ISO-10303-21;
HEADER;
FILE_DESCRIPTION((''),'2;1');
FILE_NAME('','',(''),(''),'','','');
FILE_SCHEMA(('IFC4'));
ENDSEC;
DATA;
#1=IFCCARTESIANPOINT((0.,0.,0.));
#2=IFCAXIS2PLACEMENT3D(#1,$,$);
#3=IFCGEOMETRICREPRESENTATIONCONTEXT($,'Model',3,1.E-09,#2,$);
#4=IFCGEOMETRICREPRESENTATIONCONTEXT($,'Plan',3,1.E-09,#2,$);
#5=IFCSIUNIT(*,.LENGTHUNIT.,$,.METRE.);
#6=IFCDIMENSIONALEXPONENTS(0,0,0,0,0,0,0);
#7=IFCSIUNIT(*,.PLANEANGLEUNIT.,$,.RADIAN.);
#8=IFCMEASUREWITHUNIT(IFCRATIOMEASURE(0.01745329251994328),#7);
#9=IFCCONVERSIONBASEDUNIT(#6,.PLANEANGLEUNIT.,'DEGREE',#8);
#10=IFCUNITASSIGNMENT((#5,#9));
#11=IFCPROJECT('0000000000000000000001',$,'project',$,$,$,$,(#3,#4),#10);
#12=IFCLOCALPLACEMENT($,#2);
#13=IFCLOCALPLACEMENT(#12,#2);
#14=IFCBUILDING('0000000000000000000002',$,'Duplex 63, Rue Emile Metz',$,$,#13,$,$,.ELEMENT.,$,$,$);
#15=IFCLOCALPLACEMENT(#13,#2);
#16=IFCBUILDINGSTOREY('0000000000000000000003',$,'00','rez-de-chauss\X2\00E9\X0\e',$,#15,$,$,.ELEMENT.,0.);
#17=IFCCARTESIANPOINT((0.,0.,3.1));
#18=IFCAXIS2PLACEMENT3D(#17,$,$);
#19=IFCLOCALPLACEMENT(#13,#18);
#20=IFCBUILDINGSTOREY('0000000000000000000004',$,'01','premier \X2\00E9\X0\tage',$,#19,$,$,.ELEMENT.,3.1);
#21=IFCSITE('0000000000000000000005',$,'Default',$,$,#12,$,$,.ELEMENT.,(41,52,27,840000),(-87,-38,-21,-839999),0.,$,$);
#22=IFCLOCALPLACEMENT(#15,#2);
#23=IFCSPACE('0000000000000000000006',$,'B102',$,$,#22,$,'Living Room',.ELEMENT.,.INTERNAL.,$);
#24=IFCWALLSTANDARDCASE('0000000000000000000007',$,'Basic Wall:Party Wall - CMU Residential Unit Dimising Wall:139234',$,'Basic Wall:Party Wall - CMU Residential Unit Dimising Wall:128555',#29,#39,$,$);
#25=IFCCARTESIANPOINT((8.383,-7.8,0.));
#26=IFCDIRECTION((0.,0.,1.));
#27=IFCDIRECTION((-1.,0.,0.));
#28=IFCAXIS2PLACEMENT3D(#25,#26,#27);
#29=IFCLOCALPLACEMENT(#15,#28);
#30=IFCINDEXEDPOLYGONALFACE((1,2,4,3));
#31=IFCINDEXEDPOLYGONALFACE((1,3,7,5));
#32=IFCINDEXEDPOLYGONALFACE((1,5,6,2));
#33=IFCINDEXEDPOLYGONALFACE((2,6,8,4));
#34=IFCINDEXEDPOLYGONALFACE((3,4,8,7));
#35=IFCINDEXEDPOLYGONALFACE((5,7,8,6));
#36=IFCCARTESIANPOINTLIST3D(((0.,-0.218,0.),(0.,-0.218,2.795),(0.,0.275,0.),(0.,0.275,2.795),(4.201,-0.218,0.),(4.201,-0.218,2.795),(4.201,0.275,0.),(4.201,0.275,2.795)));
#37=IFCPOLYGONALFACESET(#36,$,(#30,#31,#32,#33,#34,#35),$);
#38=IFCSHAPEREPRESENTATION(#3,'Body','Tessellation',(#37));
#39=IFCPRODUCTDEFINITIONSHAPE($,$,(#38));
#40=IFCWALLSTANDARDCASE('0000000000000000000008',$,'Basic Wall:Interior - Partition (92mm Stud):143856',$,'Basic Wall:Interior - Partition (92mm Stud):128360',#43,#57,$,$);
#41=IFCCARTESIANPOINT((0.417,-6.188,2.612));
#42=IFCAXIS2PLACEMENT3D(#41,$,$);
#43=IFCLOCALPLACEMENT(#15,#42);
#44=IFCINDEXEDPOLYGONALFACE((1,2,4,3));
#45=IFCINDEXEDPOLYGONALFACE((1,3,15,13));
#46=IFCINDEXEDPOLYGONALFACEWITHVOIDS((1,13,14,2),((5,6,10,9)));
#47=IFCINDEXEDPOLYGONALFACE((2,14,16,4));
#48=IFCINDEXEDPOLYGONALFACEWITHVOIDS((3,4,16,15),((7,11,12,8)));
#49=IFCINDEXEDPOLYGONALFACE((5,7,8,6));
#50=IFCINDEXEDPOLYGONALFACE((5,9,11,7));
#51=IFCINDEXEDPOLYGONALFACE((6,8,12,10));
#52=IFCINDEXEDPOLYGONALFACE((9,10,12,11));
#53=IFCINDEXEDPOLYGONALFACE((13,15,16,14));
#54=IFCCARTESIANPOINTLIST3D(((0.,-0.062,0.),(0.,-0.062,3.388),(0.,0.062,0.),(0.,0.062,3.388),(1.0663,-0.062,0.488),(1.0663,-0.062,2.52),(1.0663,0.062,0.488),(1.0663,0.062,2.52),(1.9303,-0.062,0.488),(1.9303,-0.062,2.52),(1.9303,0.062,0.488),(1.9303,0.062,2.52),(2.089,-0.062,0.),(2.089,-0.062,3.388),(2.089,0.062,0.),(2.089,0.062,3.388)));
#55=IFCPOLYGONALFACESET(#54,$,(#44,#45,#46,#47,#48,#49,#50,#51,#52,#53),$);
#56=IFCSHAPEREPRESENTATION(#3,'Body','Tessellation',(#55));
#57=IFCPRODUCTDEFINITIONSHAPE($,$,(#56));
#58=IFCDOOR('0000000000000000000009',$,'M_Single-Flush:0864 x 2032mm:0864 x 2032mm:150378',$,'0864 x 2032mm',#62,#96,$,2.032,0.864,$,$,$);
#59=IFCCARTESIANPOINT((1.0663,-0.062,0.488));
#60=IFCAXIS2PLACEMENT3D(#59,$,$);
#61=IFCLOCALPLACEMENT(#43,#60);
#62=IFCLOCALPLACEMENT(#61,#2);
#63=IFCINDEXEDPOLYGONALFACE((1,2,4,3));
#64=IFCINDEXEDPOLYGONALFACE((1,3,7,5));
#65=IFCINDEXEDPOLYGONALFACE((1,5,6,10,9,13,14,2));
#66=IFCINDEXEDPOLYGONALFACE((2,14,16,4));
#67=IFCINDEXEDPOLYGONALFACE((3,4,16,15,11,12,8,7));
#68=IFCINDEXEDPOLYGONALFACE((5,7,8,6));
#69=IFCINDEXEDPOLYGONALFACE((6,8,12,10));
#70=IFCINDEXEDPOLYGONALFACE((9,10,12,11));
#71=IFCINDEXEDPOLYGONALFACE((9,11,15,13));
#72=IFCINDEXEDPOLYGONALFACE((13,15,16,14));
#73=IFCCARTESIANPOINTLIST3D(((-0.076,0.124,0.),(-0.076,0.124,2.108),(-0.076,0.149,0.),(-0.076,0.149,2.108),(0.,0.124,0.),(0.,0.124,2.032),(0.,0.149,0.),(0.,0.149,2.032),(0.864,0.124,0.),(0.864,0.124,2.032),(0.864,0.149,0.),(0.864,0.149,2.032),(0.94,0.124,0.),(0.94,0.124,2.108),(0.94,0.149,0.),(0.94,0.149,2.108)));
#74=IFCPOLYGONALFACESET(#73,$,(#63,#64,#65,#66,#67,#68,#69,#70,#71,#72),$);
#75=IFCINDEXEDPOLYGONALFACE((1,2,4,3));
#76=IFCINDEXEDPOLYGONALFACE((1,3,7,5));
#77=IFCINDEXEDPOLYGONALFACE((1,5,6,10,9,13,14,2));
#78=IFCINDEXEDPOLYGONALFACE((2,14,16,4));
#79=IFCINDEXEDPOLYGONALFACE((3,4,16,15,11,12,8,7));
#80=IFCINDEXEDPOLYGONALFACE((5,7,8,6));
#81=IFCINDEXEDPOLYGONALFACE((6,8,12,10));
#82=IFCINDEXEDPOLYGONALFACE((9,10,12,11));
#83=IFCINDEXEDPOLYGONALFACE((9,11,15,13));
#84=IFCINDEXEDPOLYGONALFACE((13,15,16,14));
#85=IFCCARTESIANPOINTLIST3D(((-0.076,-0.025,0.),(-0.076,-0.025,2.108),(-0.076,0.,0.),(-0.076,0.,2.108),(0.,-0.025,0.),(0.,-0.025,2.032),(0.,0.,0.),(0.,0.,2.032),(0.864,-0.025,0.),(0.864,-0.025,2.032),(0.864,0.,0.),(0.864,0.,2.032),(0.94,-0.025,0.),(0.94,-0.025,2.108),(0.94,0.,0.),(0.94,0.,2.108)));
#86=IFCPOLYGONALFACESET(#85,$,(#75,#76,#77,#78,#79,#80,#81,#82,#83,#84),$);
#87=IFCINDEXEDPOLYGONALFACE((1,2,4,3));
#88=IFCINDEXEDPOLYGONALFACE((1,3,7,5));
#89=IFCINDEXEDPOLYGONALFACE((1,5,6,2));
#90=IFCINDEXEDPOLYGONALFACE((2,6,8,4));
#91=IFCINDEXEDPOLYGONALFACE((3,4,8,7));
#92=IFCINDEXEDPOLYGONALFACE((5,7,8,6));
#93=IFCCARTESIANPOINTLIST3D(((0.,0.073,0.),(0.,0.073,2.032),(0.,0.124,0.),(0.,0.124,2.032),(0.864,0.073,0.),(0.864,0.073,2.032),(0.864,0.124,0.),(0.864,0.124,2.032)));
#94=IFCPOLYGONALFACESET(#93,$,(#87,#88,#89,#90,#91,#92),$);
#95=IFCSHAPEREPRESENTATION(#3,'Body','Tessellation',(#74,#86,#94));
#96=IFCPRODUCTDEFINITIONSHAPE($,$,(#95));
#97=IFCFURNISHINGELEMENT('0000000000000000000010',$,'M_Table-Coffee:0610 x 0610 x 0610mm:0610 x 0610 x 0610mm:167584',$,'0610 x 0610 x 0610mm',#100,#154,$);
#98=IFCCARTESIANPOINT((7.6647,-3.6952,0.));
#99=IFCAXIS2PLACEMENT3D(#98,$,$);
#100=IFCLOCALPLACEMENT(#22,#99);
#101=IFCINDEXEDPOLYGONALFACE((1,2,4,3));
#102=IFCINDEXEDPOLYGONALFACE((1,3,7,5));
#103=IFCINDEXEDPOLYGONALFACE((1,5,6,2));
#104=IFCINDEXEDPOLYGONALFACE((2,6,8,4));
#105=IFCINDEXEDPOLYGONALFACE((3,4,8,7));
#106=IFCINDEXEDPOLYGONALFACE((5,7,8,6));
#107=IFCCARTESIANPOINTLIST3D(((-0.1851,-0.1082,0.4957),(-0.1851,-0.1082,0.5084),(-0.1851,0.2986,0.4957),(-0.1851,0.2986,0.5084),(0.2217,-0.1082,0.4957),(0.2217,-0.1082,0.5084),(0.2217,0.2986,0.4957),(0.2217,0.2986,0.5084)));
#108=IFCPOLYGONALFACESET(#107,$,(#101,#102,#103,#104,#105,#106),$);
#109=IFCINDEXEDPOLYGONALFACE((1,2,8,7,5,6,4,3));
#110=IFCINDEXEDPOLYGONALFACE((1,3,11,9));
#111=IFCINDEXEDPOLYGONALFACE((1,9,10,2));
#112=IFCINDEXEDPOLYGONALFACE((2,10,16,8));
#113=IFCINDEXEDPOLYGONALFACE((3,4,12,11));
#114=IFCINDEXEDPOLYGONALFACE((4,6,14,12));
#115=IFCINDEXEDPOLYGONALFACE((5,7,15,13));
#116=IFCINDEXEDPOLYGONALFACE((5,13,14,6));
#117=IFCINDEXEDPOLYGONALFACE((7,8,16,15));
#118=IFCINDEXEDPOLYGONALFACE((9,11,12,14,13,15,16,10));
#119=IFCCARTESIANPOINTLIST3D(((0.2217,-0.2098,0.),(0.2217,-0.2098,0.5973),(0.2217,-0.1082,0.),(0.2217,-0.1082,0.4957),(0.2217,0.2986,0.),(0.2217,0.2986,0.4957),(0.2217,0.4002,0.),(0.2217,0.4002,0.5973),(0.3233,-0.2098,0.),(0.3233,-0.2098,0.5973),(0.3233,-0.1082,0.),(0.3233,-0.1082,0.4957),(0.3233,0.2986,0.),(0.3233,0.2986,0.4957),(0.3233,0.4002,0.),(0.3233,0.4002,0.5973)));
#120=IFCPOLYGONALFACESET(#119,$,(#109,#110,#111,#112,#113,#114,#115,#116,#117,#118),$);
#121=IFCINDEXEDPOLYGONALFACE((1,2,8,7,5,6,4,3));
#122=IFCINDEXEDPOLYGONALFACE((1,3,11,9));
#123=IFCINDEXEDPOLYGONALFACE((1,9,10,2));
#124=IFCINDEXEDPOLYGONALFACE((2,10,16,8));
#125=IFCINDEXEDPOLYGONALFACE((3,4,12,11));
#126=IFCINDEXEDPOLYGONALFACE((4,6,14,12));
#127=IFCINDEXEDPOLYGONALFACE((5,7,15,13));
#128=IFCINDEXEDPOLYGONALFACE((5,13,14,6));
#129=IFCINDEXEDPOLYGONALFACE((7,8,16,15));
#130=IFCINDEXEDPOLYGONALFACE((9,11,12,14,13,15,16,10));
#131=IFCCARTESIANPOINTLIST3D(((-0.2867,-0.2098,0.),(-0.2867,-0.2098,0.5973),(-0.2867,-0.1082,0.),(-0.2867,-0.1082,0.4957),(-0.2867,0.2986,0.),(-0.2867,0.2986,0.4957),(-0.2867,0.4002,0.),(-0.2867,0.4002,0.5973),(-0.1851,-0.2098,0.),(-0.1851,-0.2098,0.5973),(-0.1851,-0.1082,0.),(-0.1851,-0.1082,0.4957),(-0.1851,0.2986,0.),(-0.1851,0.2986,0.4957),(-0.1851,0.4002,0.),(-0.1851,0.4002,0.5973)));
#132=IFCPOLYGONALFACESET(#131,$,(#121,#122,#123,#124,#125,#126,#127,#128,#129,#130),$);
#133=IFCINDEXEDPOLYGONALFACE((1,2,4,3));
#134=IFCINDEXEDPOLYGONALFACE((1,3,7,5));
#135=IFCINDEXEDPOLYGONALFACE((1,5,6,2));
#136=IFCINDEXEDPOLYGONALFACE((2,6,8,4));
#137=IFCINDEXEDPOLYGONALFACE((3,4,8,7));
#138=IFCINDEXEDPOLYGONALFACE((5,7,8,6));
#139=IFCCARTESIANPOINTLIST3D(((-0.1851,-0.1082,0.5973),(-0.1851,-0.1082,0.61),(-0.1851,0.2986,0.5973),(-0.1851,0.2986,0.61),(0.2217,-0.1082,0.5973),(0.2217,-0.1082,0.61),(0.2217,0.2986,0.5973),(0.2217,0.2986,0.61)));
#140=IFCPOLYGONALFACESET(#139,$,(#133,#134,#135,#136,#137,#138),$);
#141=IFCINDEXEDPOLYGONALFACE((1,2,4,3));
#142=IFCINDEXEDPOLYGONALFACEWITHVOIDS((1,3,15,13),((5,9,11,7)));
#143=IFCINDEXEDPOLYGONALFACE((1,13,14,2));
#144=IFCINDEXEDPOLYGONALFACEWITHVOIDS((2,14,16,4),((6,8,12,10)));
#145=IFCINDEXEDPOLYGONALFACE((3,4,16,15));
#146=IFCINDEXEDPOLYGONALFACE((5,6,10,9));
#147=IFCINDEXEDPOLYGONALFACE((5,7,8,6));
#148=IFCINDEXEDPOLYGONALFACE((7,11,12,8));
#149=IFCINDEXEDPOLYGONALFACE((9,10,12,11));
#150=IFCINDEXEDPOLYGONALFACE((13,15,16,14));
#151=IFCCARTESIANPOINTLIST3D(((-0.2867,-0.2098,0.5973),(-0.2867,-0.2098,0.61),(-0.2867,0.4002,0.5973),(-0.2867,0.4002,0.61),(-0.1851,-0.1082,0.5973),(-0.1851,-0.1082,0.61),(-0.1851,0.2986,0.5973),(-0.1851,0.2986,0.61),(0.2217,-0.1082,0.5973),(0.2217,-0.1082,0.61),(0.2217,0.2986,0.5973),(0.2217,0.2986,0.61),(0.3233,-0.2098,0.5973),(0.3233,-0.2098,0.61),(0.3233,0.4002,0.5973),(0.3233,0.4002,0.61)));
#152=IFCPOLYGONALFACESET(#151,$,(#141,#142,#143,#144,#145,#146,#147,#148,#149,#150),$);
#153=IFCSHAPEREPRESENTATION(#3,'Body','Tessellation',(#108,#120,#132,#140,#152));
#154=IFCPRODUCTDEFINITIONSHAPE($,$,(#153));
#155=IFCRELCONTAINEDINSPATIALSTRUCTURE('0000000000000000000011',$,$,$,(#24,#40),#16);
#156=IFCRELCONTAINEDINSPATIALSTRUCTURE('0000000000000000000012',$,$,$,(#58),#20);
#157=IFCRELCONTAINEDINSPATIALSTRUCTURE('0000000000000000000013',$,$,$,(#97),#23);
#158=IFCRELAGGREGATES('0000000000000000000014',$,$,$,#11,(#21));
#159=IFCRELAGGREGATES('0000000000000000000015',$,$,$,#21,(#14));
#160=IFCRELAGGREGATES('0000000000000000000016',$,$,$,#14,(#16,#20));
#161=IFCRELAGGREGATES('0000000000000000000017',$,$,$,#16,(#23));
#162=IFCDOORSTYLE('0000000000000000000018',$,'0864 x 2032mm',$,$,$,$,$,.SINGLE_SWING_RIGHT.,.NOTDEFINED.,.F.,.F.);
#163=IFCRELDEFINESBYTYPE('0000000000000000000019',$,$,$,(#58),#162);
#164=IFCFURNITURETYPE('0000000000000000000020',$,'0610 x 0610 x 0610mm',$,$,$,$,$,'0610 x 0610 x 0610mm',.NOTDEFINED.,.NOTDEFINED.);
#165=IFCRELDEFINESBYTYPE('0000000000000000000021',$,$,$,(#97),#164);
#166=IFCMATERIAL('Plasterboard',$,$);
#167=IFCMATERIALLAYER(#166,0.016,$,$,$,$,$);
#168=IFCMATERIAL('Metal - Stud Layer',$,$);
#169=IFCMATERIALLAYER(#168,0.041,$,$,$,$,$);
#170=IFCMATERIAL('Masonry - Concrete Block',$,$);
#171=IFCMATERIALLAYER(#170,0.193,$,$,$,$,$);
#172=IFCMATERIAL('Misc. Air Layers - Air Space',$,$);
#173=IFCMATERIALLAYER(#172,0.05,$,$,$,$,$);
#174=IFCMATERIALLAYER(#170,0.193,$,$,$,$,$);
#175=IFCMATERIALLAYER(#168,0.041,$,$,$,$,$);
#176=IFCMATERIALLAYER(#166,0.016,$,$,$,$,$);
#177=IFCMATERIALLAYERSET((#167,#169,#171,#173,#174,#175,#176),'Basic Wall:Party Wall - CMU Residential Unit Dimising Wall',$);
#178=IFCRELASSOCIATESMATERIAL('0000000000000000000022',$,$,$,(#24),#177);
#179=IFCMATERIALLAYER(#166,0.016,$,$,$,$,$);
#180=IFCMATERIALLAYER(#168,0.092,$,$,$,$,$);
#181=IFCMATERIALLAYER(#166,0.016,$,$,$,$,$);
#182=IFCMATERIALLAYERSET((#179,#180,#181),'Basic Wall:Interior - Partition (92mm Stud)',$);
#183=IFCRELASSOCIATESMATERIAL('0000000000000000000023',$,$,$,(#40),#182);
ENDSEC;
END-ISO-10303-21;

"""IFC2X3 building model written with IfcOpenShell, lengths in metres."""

from ifc_helpers import new_model, entity, si_unit, converted_unit, frame, frame_2d, origin, origin_2d_with_axis, place, context, project, spatial, polyline, rectangle, outline, extrude, clip, bounded_halfspace, source, transform, mapped, material, layer, layer_set, layer_usage, type_object, type_shapes, element, fill, save


model = new_model("IFC2X3")

# Units and contexts
model_context = context("Model", 3, precision=1e-09, world=origin())
plan_context = context("Plan", 3, precision=1e-09, world=origin())
ifc_project = project(units=[si_unit("LENGTHUNIT", "METRE"), converted_unit("PLANEANGLEUNIT", "DEGREE", entity("IfcRatioMeasure", 0.01745329251994328), si_unit("PLANEANGLEUNIT", "RADIAN"), dimensions=[0, 0, 0, 0, 0, 0, 0])], contexts=[model_context, plan_context])

# Site, building, storey
site_placement = place(None, origin())
site = spatial("IfcSite", under=ifc_project, at=site_placement, Name="Default", CompositionType="ELEMENT", RefLatitude=(41, 52, 27, 840000), RefLongitude=(-87, -38, -21, -839999), RefElevation=0.0)
building_placement = place(site_placement, origin())
building = spatial("IfcBuilding", under=site, at=building_placement, Name="Duplex 63, Rue Emile Metz", CompositionType="ELEMENT")
storey_1_placement = place(building_placement, origin())
storey_1 = spatial("IfcBuildingStorey", under=building, at=storey_1_placement, Name="00", Description="rez-de-chaussée", CompositionType="ELEMENT", Elevation=0.0)

# Shared definitions
ifc_material_1 = material(Name="Misc. Air Layers - Air Space")
ifc_material_2 = material(Name="Masonry - Concrete Block")
ifc_material_3 = material(Name="Metal - Stud Layer")
ifc_material_4 = material(Name="Plasterboard")

# Wall
ifc_layer_1 = layer(ifc_material_4, 0.016)
ifc_layer_2 = layer(ifc_material_3, 0.041)
ifc_layer_3 = layer(ifc_material_2, 0.193)
ifc_layer_4 = layer(ifc_material_1, 0.05)
ifc_layer_5 = layer(ifc_material_2, 0.193)
ifc_layer_6 = layer(ifc_material_3, 0.041)
ifc_layer_7 = layer(ifc_material_4, 0.016)
ifc_layer_set_1 = layer_set([ifc_layer_1, ifc_layer_2, ifc_layer_3, ifc_layer_4, ifc_layer_5, ifc_layer_6, ifc_layer_7], Name="Basic Wall:Party Wall - CMU Residential Unit Dimising Wall")
ifc_layer_usage_1 = layer_usage(ifc_layer_set_1, "AXIS2", "NEGATIVE", 0.275)
wall_1_placement = place(storey_1_placement, frame((8.383, -7.8, 0.0), z_axis=(0.0, 0.0, 1.0), x_axis=(-1.0, 0.0, 0.0)))
element("IfcWallStandardCase", 1, at=wall_1_placement, inside=storey_1, material=ifc_layer_usage_1, Name="Basic Wall:Party Wall - CMU Residential Unit Dimising Wall:139234", ObjectType="Basic Wall:Party Wall - CMU Residential Unit Dimising Wall:128555", context=model_context, shape_type="Clipping", body=[
    clip(clip(extrude(rectangle(XDim=4.201, YDim=0.55, at=frame_2d((2.1005, 0.0), x_axis=(-1.0, 0.0))), origin(), (0.0, 0.0, 1.0), 2.795), bounded_halfspace(frame((0.0, -0.218, 2.795), z_axis=(0.0, 1.0, 0.0), x_axis=(-1.0, 0.0, 0.0)), True, frame((0.0, -0.218, 2.795), z_axis=(0.0, 1.0, 0.0), x_axis=(-1.0, 0.0, 0.0)), polyline([(0.0, 0.0), (-3.708, 0.0), (-4.201, 0.0), (-4.201, -2.795), (0.0, -2.795), (0.0, 0.0)]))), bounded_halfspace(frame((4.201, 0.275, 0.0), z_axis=(-1.0, 0.0, 0.0), x_axis=(0.0, -1.0, 0.0)), True, frame((4.201, 0.275, 0.0), z_axis=(-1.0, 0.0, 0.0), x_axis=(0.0, -1.0, 0.0)), polyline([(0.0, 0.0), (0.493, 0.0), (0.493, 2.795), (0.0, 2.795), (0.0, 0.0)]))),
])

# Wall, opening
ifc_layer_8 = layer(ifc_material_4, 0.016)
ifc_layer_9 = layer(ifc_material_3, 0.092)
ifc_layer_10 = layer(ifc_material_4, 0.016)
ifc_layer_set_2 = layer_set([ifc_layer_8, ifc_layer_9, ifc_layer_10], Name="Basic Wall:Interior - Partition (92mm Stud)")
ifc_layer_usage_2 = layer_usage(ifc_layer_set_2, "AXIS2", "NEGATIVE", 0.062)
wall_2_placement = place(storey_1_placement, frame((0.417, -6.188, 2.612)))
wall_2 = element("IfcWallStandardCase", 2, at=wall_2_placement, inside=storey_1, material=ifc_layer_usage_2, Name="Basic Wall:Interior - Partition (92mm Stud):143856", ObjectType="Basic Wall:Interior - Partition (92mm Stud):128360", context=model_context, shape_type="SweptSolid", body=[
    extrude(rectangle(XDim=2.089, YDim=0.124, at=frame_2d((1.0445, 0.0), x_axis=(-1.0, 0.0))), origin(), (0.0, 0.0, 1.0), 3.388),
])
opening_1_placement = place(wall_2_placement, frame((1.0663, -0.062, 0.488)))
opening_1 = element("IfcOpeningElement", 3, at=opening_1_placement, cuts=wall_2, ObjectType="Opening", context=model_context, shape_type="SweptSolid", body=[
    extrude(rectangle(XDim=0.864, YDim=2.032, at=frame_2d((1.016, 0.432), x_axis=(0.0, 1.0))), frame((0.0, 0.0, 0.0), z_axis=(0.0, 1.0, 0.0), x_axis=(0.0, 0.0, 1.0)), (0.0, 0.0, 1.0), 0.124),
])

# Shared definitions
storey_2_placement = place(building_placement, frame((0.0, 0.0, 3.1)))
storey_2 = spatial("IfcBuildingStorey", under=building, at=storey_2_placement, Name="01", Description="premier étage", CompositionType="ELEMENT", Elevation=3.1)

# Door
door_style_1 = type_object("IfcDoorStyle", Name="0864 x 2032mm", ConstructionType="NOTDEFINED", OperationType="SINGLE_SWING_RIGHT", ParameterTakesPrecedence=False, Sizeable=False)
shared_shape_1 = source(origin(), model_context, "Body", "SweptSolid", [
    extrude(outline(polyline([(-0.508, -1.073), (0.508, -1.073), (0.508, 1.035), (0.432, 1.035), (0.432, -0.997), (-0.432, -0.997), (-0.432, 1.035), (-0.508, 1.035), (-0.508, -1.073)])), frame((0.432, 0.124, 1.035), z_axis=(0.0, 1.0, 0.0), x_axis=(1.0, 0.0, 0.0)), (0.0, 0.0, 1.0), 0.025),
    extrude(outline(polyline([(-1.073, -0.508), (1.035, -0.508), (1.035, -0.432), (-0.997, -0.432), (-0.997, 0.432), (1.035, 0.432), (1.035, 0.508), (-1.073, 0.508), (-1.073, -0.508)])), frame((0.432, -0.025, 1.035), z_axis=(0.0, 1.0, 0.0), x_axis=(0.0, 0.0, -1.0)), (0.0, 0.0, 1.0), 0.025),
    extrude(rectangle(XDim=0.051, YDim=0.864, at=origin_2d_with_axis()), frame((0.432, 0.0985, 0.0), z_axis=(0.0, 0.0, 1.0), x_axis=(0.0, 1.0, 0.0)), (0.0, 0.0, 1.0), 2.032),
])
type_shapes(door_style_1, [shared_shape_1])
door_1_placement = place(opening_1_placement, origin())
door_1 = element("IfcDoor", 4, at=door_1_placement, inside=storey_2, type_object=door_style_1, Name="M_Single-Flush:0864 x 2032mm:0864 x 2032mm:150378", ObjectType="0864 x 2032mm", OverallHeight=2.032, OverallWidth=0.864, context=model_context, shape_type="MappedRepresentation", body=[
    mapped(shared_shape_1, transform((0.0, 0.0, 0.0), scale=1.0)),
])
fill(opening_1, door_1)

# Shared definitions
space_1_placement = place(storey_1_placement, origin())
space_1 = spatial("IfcSpace", under=storey_1, at=space_1_placement, Name="B102", LongName="Living Room", CompositionType="ELEMENT", InteriorOrExteriorSpace="INTERNAL")

# Furnishing element
furniture_type_1 = type_object("IfcFurnitureType", Name="0610 x 0610 x 0610mm", ElementType="0610 x 0610 x 0610mm", AssemblyPlace="NOTDEFINED")
shared_shape_2 = source(origin(), model_context, "Body", "SweptSolid", [
    extrude(rectangle(XDim=0.4068, YDim=0.4068, at=origin_2d_with_axis()), frame((0.0183, 0.0952, 0.4957), z_axis=(0.0, 0.0, 1.0), x_axis=(-1.0, 0.0, 0.0)), (0.0, 0.0, 1.0), 0.0127),
    extrude(outline(polyline([(-0.2732, -0.305), (0.324, -0.305), (0.324, 0.305), (-0.2732, 0.305), (-0.2732, 0.2034), (0.2225, 0.2034), (0.2225, -0.2034), (-0.2732, -0.2034), (-0.2732, -0.305)])), frame((0.2217, 0.0952, 0.2732), z_axis=(1.0, 0.0, 0.0), x_axis=(0.0, 0.0, 1.0)), (0.0, 0.0, 1.0), 0.1016),
    extrude(outline(polyline([(-0.305, -0.3241), (0.305, -0.3241), (0.305, 0.2733), (0.2034, 0.2733), (0.2034, -0.2224), (-0.2034, -0.2224), (-0.2034, 0.2733), (-0.305, 0.2733), (-0.305, -0.3241)])), frame((-0.2867, 0.0952, 0.2733), z_axis=(1.0, 0.0, 0.0), x_axis=(0.0, -1.0, 0.0)), (0.0, 0.0, 1.0), 0.1016),
    extrude(rectangle(XDim=0.4068, YDim=0.4068, at=origin_2d_with_axis()), frame((0.0183, 0.0952, 0.5973), z_axis=(0.0, 0.0, 1.0), x_axis=(-1.0, 0.0, 0.0)), (0.0, 0.0, 1.0), 0.0127),
    extrude(outline(polyline([(-0.305, -0.305), (0.305, -0.305), (0.305, 0.305), (-0.305, 0.305), (-0.305, -0.305)]), holes=[polyline([(-0.2034, -0.2034), (-0.2034, 0.2034), (0.2034, 0.2034), (0.2034, -0.2034), (-0.2034, -0.2034)])]), frame((0.0183, 0.0952, 0.5973), z_axis=(0.0, 0.0, 1.0), x_axis=(-1.0, 0.0, 0.0)), (0.0, 0.0, 1.0), 0.0127),
])
type_shapes(furniture_type_1, [shared_shape_2])
for number, where, name in (
    (5, (7.6647, -3.6952, 0.0), "M_Table-Coffee:0610 x 0610 x 0610mm:0610 x 0610 x 0610mm:167584"),
):
    element("IfcFurnishingElement", number, at=place(space_1_placement, frame(where)), inside=space_1, type_object=furniture_type_1, Name=name, ObjectType="0610 x 0610 x 0610mm", context=model_context, shape_type="MappedRepresentation", body=[
        mapped(shared_shape_2, transform((0.0, 0.0, 0.0), scale=1.0)),
    ])

save(model, "model.ifc")
